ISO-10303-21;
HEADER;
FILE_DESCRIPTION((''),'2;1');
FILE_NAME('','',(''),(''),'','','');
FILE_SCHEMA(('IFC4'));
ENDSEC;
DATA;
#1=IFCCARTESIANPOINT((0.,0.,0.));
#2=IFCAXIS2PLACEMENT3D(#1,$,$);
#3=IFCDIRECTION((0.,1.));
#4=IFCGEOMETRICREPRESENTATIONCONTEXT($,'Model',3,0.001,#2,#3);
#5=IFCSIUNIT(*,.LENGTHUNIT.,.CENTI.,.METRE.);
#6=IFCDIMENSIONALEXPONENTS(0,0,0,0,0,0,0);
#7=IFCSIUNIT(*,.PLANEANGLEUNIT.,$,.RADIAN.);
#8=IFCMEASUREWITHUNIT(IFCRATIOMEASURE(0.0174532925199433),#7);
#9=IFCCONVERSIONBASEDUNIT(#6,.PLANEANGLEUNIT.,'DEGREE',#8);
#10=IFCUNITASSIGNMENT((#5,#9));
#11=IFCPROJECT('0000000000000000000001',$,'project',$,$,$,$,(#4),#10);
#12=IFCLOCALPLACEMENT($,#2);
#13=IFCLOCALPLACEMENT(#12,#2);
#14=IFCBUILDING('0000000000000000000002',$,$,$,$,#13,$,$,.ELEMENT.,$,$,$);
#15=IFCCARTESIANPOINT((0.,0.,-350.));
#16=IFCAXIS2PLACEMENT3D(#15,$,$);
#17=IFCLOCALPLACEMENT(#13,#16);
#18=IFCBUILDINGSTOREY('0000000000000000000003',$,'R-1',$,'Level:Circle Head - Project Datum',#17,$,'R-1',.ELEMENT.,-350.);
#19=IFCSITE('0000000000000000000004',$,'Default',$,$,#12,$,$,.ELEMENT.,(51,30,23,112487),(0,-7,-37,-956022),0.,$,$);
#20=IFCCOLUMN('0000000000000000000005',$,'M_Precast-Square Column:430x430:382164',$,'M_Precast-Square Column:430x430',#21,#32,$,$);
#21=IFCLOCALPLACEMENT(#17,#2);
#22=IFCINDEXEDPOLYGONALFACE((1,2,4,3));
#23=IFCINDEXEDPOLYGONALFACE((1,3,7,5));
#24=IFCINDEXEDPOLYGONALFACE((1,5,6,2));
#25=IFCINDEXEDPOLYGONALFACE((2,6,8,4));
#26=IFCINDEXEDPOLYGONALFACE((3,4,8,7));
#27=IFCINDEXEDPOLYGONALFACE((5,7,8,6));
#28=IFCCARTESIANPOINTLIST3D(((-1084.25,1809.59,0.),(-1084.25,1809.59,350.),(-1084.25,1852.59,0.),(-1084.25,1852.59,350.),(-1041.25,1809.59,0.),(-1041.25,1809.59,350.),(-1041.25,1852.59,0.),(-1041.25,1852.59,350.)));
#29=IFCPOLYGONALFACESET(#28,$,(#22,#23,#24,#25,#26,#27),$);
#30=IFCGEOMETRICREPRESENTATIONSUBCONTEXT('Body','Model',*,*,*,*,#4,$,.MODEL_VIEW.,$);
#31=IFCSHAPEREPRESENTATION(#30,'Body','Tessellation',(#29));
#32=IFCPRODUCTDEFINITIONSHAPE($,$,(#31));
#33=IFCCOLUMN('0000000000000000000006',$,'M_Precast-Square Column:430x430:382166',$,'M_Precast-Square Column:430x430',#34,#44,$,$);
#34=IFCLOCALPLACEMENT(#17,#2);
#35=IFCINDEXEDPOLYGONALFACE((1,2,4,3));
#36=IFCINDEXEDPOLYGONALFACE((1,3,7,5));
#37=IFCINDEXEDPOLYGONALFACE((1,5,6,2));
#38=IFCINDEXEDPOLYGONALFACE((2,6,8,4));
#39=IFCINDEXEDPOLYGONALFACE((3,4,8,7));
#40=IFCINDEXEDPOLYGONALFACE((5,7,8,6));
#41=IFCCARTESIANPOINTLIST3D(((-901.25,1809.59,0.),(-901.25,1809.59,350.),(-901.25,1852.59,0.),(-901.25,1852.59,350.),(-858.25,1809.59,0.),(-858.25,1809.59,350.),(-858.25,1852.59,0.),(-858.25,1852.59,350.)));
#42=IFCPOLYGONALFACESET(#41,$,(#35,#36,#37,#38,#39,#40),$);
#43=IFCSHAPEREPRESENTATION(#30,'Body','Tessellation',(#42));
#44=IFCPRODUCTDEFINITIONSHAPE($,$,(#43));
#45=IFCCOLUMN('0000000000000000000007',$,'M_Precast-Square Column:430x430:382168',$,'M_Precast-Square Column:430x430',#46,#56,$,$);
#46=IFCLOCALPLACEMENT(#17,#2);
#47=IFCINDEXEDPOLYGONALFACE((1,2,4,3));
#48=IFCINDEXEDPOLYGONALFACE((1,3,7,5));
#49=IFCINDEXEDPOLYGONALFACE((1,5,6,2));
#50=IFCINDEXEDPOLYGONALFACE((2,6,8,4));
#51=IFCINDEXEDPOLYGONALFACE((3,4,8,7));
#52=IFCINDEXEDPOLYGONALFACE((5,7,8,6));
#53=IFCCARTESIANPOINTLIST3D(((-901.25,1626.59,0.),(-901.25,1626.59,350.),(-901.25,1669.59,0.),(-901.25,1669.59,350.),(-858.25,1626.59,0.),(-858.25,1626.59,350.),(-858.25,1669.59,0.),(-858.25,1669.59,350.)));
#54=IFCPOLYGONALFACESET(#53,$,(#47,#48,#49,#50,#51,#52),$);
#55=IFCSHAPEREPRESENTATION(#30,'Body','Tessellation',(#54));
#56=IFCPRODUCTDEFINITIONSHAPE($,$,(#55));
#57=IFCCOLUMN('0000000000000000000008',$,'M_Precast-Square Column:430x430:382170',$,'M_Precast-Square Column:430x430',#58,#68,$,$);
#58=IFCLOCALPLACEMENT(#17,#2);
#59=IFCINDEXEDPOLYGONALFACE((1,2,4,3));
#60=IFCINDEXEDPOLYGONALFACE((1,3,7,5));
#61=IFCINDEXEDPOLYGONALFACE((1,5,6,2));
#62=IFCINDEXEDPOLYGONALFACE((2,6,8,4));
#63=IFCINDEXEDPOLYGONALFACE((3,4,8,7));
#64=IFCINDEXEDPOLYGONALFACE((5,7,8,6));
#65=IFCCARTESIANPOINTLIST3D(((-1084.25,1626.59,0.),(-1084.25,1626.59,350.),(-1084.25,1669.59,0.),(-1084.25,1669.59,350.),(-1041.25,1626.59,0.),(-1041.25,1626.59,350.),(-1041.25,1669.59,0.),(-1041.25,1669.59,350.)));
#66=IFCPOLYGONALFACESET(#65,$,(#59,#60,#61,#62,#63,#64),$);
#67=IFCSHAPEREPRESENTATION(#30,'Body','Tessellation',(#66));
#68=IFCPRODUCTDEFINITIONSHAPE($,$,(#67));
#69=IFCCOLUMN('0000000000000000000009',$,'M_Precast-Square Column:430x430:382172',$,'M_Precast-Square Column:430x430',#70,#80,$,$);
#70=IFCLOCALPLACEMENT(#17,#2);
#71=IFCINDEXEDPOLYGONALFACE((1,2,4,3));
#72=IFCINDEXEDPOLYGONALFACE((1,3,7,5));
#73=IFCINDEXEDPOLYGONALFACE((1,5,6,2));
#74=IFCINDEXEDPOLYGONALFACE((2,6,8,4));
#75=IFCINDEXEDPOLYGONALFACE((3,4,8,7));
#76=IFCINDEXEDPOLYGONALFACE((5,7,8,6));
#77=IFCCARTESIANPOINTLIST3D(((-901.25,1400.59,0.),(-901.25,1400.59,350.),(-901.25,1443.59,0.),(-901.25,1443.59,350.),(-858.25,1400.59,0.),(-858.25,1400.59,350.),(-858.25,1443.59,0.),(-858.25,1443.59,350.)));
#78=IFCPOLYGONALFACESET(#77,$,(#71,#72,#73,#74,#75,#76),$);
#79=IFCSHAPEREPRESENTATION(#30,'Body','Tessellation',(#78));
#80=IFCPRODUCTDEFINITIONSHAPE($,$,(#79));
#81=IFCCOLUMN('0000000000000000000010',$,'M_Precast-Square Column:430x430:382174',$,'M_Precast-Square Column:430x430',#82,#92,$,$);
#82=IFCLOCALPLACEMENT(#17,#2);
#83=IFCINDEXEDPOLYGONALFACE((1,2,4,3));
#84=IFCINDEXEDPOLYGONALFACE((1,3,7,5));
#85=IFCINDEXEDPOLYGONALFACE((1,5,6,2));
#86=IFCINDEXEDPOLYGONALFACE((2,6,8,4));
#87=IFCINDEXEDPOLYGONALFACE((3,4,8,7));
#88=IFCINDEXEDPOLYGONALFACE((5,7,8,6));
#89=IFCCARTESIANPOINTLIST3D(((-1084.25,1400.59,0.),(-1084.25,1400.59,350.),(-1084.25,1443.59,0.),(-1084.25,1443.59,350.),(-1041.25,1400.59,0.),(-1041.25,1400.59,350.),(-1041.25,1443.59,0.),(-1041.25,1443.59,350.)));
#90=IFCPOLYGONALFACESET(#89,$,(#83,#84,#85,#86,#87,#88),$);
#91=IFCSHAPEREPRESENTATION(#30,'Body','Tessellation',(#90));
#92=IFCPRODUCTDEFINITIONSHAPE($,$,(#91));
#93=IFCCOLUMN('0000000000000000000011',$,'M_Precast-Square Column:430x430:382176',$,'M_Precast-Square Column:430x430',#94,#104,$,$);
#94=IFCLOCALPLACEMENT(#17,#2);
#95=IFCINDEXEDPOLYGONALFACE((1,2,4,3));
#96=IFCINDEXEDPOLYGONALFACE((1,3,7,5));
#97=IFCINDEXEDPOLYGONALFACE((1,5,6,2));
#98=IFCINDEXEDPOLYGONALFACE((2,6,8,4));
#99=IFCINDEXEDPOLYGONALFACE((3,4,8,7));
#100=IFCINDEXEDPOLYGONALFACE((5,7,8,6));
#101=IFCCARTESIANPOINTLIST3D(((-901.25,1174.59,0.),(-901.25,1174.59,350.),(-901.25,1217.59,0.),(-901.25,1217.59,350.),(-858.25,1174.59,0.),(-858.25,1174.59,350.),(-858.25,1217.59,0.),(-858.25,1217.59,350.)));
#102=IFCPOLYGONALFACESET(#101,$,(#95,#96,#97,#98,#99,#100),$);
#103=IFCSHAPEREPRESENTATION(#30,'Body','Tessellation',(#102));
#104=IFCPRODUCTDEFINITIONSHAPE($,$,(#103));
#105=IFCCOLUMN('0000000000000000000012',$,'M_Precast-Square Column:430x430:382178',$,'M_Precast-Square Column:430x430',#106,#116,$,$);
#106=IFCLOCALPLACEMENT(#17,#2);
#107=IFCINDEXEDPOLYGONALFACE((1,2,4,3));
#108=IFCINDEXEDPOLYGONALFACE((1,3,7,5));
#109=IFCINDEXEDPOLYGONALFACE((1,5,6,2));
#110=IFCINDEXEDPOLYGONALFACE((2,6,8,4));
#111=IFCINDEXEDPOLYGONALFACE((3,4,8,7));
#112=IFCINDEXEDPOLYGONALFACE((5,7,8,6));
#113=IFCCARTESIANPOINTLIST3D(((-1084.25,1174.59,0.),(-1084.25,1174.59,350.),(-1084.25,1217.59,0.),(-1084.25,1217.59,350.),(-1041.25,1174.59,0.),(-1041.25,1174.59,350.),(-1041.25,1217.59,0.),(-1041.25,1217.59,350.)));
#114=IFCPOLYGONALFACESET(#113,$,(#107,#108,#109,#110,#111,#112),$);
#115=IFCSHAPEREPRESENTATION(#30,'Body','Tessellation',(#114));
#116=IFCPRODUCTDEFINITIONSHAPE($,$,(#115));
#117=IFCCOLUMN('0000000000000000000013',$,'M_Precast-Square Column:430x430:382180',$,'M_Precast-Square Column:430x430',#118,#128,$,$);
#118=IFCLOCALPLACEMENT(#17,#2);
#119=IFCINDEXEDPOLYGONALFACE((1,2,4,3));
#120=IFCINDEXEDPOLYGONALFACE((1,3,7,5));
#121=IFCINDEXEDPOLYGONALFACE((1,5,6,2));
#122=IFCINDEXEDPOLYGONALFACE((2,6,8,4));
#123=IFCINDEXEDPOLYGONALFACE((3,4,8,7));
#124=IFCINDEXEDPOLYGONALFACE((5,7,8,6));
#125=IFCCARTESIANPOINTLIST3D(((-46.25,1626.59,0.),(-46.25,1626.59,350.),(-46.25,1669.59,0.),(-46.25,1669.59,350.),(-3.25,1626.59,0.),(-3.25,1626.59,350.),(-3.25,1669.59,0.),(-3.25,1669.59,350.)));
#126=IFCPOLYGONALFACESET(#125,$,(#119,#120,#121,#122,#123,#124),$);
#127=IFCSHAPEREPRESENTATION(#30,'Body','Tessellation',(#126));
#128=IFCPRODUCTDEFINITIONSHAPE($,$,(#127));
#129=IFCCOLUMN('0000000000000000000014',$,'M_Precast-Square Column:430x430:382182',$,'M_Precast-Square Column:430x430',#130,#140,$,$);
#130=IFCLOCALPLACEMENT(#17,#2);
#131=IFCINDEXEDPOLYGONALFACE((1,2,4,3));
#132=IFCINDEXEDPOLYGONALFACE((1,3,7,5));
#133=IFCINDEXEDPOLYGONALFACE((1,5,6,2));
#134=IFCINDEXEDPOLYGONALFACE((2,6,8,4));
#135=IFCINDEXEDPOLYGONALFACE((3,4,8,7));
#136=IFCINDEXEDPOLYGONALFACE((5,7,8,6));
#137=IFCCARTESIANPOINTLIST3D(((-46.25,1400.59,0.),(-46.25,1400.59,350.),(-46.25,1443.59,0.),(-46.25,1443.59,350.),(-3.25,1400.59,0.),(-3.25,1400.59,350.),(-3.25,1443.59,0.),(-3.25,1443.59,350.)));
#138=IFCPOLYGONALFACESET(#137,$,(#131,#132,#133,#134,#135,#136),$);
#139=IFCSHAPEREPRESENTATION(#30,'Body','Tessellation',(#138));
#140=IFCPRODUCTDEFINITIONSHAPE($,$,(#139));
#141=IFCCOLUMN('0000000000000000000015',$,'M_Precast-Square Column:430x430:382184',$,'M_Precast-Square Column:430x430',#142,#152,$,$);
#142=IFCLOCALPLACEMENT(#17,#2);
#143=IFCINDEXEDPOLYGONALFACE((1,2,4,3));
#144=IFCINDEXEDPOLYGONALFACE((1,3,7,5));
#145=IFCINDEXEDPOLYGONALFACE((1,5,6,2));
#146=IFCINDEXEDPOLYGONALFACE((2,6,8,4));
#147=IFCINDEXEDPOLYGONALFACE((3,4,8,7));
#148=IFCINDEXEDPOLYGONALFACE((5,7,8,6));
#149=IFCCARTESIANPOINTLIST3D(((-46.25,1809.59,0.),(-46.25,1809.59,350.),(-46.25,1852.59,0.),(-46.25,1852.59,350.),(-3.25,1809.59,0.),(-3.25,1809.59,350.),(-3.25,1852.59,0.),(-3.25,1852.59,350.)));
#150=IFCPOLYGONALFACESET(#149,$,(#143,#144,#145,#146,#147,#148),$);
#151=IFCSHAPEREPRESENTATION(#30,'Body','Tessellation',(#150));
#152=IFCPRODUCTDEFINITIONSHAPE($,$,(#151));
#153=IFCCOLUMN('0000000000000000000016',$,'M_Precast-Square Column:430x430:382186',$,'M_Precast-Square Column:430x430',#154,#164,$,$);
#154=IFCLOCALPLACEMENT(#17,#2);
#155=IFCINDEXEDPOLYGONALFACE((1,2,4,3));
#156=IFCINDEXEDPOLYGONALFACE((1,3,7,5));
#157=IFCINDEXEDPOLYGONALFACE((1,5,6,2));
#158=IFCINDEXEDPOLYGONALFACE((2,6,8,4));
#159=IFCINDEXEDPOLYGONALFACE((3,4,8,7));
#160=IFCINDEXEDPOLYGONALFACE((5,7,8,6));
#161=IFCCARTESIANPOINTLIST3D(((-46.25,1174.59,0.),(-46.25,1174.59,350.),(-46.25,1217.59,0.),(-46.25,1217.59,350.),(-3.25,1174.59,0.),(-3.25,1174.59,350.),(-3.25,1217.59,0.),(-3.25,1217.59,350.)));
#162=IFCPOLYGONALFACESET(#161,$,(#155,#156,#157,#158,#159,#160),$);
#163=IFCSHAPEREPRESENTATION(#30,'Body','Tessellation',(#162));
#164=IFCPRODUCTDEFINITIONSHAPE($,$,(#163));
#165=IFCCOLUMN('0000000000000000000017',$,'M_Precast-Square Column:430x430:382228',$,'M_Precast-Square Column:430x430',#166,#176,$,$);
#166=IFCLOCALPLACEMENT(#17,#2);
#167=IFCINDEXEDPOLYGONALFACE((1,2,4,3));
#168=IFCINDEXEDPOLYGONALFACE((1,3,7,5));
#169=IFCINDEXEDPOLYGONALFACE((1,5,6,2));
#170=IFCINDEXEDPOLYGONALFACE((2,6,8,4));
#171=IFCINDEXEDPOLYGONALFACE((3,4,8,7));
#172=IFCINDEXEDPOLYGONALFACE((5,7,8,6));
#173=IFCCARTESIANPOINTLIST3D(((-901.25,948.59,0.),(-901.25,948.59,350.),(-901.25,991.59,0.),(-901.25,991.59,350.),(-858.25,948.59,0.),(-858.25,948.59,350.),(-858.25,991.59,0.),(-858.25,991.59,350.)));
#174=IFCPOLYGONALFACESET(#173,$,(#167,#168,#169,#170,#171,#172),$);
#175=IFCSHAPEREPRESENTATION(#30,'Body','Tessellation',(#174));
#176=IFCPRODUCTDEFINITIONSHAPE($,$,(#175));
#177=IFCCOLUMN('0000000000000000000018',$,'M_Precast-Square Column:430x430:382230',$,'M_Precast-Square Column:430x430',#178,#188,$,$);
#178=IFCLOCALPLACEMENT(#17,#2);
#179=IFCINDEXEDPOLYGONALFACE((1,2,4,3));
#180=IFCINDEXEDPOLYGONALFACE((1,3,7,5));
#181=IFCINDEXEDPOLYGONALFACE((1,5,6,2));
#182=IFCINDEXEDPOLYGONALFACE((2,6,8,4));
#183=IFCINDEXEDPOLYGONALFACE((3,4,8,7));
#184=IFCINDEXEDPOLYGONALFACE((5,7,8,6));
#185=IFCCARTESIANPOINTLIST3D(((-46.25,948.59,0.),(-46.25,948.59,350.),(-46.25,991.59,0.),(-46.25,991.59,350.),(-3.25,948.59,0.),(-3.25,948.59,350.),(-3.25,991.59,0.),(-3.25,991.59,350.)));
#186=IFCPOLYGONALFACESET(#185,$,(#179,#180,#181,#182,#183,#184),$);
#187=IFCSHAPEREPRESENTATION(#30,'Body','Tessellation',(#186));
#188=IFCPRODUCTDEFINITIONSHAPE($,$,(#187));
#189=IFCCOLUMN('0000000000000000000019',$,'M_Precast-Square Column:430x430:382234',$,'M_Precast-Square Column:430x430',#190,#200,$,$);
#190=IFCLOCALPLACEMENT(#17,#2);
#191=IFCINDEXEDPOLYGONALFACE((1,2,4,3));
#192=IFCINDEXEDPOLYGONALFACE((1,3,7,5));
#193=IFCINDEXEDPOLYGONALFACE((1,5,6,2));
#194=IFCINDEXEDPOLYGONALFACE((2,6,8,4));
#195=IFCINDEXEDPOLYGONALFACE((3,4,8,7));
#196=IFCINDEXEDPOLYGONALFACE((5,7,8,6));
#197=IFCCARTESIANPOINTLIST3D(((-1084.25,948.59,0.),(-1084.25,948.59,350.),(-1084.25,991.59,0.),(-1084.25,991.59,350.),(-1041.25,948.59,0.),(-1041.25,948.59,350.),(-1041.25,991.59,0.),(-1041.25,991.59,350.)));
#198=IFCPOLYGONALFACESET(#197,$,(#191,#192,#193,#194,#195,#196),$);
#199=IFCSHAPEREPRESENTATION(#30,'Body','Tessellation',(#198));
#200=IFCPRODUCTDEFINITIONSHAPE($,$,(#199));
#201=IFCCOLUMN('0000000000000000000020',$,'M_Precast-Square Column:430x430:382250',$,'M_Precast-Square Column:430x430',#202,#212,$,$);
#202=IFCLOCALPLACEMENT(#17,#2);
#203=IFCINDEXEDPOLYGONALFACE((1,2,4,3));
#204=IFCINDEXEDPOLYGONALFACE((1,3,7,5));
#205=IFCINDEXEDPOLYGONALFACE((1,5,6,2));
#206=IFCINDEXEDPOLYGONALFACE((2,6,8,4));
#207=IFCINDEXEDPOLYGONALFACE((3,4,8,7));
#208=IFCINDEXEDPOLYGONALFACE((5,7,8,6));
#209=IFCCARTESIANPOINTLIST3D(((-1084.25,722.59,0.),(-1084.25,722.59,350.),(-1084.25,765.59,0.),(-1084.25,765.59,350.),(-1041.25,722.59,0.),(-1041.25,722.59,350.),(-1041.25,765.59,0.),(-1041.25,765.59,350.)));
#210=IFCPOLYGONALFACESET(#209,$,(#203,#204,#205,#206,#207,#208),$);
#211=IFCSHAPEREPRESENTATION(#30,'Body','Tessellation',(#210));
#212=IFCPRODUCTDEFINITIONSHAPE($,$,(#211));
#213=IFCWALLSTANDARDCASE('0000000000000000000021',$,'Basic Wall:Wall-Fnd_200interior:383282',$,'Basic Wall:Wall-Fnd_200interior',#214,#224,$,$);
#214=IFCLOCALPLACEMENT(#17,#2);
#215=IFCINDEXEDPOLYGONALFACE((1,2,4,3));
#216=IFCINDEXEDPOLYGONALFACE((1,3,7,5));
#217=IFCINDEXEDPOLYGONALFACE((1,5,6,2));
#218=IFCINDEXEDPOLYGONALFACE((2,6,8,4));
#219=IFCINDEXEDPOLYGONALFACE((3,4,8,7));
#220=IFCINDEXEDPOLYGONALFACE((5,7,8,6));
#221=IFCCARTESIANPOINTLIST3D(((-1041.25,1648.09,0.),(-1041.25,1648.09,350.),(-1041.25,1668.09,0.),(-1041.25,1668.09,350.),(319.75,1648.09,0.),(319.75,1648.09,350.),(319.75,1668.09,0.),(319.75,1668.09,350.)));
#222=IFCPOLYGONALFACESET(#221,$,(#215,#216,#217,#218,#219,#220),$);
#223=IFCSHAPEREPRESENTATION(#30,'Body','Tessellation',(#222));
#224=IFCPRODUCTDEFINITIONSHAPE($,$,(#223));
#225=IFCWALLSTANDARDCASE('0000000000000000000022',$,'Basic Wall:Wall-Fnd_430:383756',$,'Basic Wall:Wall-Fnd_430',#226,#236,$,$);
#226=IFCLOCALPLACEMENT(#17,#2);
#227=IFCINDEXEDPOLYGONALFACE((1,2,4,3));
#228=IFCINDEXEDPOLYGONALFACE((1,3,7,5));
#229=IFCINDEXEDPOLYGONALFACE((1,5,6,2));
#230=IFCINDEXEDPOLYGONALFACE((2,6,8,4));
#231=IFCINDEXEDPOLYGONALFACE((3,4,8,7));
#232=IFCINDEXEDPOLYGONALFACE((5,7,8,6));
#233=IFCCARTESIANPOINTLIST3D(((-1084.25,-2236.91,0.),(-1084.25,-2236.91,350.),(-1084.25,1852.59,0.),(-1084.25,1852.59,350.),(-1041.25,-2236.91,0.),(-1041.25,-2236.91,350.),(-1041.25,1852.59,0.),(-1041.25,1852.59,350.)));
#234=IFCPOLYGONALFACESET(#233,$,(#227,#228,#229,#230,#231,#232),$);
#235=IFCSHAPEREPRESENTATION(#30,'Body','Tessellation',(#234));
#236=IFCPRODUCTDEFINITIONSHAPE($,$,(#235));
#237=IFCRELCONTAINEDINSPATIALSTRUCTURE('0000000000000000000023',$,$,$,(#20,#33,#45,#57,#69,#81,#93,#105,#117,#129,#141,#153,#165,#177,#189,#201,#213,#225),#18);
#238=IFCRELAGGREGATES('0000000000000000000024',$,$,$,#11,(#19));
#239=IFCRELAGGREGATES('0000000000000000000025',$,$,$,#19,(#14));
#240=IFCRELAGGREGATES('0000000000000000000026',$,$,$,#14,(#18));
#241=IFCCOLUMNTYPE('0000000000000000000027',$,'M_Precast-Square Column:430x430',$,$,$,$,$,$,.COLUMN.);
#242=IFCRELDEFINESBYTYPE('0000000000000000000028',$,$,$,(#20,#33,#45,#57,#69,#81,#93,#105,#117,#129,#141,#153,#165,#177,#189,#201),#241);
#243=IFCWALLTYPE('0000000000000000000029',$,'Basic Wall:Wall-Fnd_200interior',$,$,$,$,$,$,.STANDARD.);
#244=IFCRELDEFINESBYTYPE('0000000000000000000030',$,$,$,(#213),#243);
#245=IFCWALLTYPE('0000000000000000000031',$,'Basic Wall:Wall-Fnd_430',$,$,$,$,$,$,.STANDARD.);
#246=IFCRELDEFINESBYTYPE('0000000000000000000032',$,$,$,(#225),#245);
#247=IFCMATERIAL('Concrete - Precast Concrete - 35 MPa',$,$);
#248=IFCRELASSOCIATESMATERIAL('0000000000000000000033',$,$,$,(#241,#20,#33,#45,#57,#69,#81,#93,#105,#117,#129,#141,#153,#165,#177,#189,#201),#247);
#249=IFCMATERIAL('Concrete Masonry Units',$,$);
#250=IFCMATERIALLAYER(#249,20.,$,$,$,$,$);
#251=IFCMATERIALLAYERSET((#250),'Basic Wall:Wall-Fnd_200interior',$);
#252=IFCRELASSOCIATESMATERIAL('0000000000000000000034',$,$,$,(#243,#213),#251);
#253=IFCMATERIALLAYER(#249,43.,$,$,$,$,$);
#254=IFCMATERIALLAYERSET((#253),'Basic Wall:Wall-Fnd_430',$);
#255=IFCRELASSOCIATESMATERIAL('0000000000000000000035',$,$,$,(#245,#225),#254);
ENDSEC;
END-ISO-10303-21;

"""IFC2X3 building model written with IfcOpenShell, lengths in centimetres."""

from ifc_helpers import new_model, entity, si_unit, converted_unit, direction, frame, frame_2d, origin, origin_2d_with_axis, place, context, subcontext, project, spatial, rectangle, extrude, source, transform, mapped, material, layer, layer_set, layer_usage, type_object, type_shapes, element, save


model = new_model("IFC2X3")

# Units and contexts
model_context = context("Model", 3, precision=0.001, world=origin(), true_north=direction((0.0, 1.0)))
body_context = subcontext(model_context, "Body", "Model", "MODEL_VIEW")
ifc_project = project(units=[si_unit("LENGTHUNIT", "METRE", prefix="CENTI"), converted_unit("PLANEANGLEUNIT", "DEGREE", entity("IfcRatioMeasure", 0.0174532925199433), si_unit("PLANEANGLEUNIT", "RADIAN"), dimensions=[0, 0, 0, 0, 0, 0, 0])], contexts=[model_context])

# Site, building, storey
site_placement = place(None, origin())
site = spatial("IfcSite", under=ifc_project, at=site_placement, Name="Default", CompositionType="ELEMENT", RefLatitude=(51, 30, 23, 112487), RefLongitude=(0, -7, -37, -956022), RefElevation=0.0)
building_placement = place(site_placement, origin())
building = spatial("IfcBuilding", under=site, at=building_placement, CompositionType="ELEMENT")
storey_placement = place(building_placement, frame((0.0, 0.0, -350.0)))
storey = spatial("IfcBuildingStorey", under=building, at=storey_placement, Name="R-1", ObjectType="Level:Circle Head - Project Datum", LongName="R-1", CompositionType="ELEMENT", Elevation=-350.0)

# Columns
ifc_material_1 = material(Name="Concrete - Precast Concrete - 35 MPa")
column_type = type_object("IfcColumnType", Name="M_Precast-Square Column:430x430", PredefinedType="COLUMN", material=ifc_material_1)
shared_shape = source(origin(), body_context, "Body", "SweptSolid", [
    extrude(rectangle(XDim=43.0, YDim=43.0, at=origin_2d_with_axis()), frame((0.0, 0.0, -350.0), z_axis=(0.0, 0.0, 1.0), x_axis=(0.0, -1.0, 0.0)), (0.0, 0.0, 1.0), 350.0),
])
type_shapes(column_type, [shared_shape])
for number, where, z_axis, x_axis, name in (
    (1, (-1062.75, 1831.09, 350.0), (0.0, 0.0, 1.0), (-1.0, 0.0, 0.0), "M_Precast-Square Column:430x430:382164"),
    (2, (-879.75, 1831.09, 350.0), (0.0, 0.0, 1.0), (-1.0, 0.0, 0.0), "M_Precast-Square Column:430x430:382166"),
    (3, (-879.75, 1648.09, 350.0), (0.0, 0.0, 1.0), (-1.0, 0.0, 0.0), "M_Precast-Square Column:430x430:382168"),
    (4, (-1062.75, 1648.09, 350.0), (0.0, 0.0, 1.0), (-1.0, 0.0, 0.0), "M_Precast-Square Column:430x430:382170"),
    (5, (-879.75, 1422.09, 350.0), (0.0, 0.0, 1.0), (-1.0, 0.0, 0.0), "M_Precast-Square Column:430x430:382172"),
    (6, (-1062.75, 1422.09, 350.0), (0.0, 0.0, 1.0), (-1.0, 0.0, 0.0), "M_Precast-Square Column:430x430:382174"),
    (7, (-879.75, 1196.09, 350.0), (0.0, 0.0, 1.0), (-1.0, 0.0, 0.0), "M_Precast-Square Column:430x430:382176"),
    (8, (-1062.75, 1196.09, 350.0), (0.0, 0.0, 1.0), (-1.0, 0.0, 0.0), "M_Precast-Square Column:430x430:382178"),
    (9, (-24.75, 1648.09, 350.0), (0.0, 0.0, 1.0), (-1.0, 0.0, 0.0), "M_Precast-Square Column:430x430:382180"),
    (10, (-24.75, 1422.09, 350.0), (0.0, 0.0, 1.0), (-1.0, 0.0, 0.0), "M_Precast-Square Column:430x430:382182"),
    (11, (-24.75, 1831.09, 350.0), (0.0, 0.0, 1.0), (-1.0, 0.0, 0.0), "M_Precast-Square Column:430x430:382184"),
    (12, (-24.75, 1196.09, 350.0), (0.0, 0.0, 1.0), (-1.0, 0.0, 0.0), "M_Precast-Square Column:430x430:382186"),
    (13, (-879.75, 970.09, 350.0), (0.0, 0.0, 1.0), (-1.0, 0.0, 0.0), "M_Precast-Square Column:430x430:382228"),
    (14, (-24.75, 970.09, 350.0), (0.0, 0.0, 1.0), (-1.0, 0.0, 0.0), "M_Precast-Square Column:430x430:382230"),
    (15, (-1062.75, 970.09, 350.0), (0.0, 0.0, 1.0), (-1.0, 0.0, 0.0), "M_Precast-Square Column:430x430:382234"),
    (16, (-1062.75, 744.09, 350.0), (0.0, 0.0, 1.0), (-1.0, 0.0, 0.0), "M_Precast-Square Column:430x430:382250"),
):
    element("IfcColumn", number, at=place(storey_placement, frame(where, z_axis=z_axis, x_axis=x_axis)), inside=storey, type_object=column_type, material=ifc_material_1, Name=name, ObjectType="M_Precast-Square Column:430x430", context=body_context, shape_type="MappedRepresentation", body=[
        mapped(shared_shape, transform((0.0, 0.0, 0.0), scale=1.0)),
    ])

# Walls
ifc_material_2 = material(Name="Concrete Masonry Units")
ifc_layer_1 = layer(ifc_material_2, 20.0)
ifc_layer_set_1 = layer_set([ifc_layer_1], Name="Basic Wall:Wall-Fnd_200interior")
ifc_layer_usage_1 = layer_usage(ifc_layer_set_1, "AXIS2", "POSITIVE", -10.0)
wall_type_1 = type_object("IfcWallType", Name="Basic Wall:Wall-Fnd_200interior", PredefinedType="STANDARD", material=ifc_layer_set_1)
wall_1_placement = place(storey_placement, frame((-1041.25, 1658.09, 0.0)))
element("IfcWallStandardCase", 17, at=wall_1_placement, inside=storey, type_object=wall_type_1, material=ifc_layer_usage_1, Name="Basic Wall:Wall-Fnd_200interior:383282", ObjectType="Basic Wall:Wall-Fnd_200interior", context=body_context, shape_type="SweptSolid", body=[
    extrude(rectangle(XDim=1361.0, YDim=20.0, at=frame_2d((680.5, 0.0), x_axis=(-1.0, 0.0))), origin(), (0.0, 0.0, 1.0), 350.0),
])
ifc_layer_2 = layer(ifc_material_2, 43.0)
ifc_layer_set_2 = layer_set([ifc_layer_2], Name="Basic Wall:Wall-Fnd_430")
ifc_layer_usage_2 = layer_usage(ifc_layer_set_2, "AXIS2", "NEGATIVE", 21.5)
wall_type_2 = type_object("IfcWallType", Name="Basic Wall:Wall-Fnd_430", PredefinedType="STANDARD", material=ifc_layer_set_2)
wall_2_placement = place(storey_placement, frame((-1062.75, 1852.59, 0.0), z_axis=(0.0, 0.0, 1.0), x_axis=(0.0, -1.0, 0.0)))
element("IfcWallStandardCase", 18, at=wall_2_placement, inside=storey, type_object=wall_type_2, material=ifc_layer_usage_2, Name="Basic Wall:Wall-Fnd_430:383756", ObjectType="Basic Wall:Wall-Fnd_430", context=body_context, shape_type="SweptSolid", body=[
    extrude(rectangle(XDim=4089.5, YDim=43.0, at=frame_2d((2044.75, 0.0), x_axis=(-1.0, 0.0))), origin(), (0.0, 0.0, 1.0), 350.0),
])

save(model, "model.ifc")
